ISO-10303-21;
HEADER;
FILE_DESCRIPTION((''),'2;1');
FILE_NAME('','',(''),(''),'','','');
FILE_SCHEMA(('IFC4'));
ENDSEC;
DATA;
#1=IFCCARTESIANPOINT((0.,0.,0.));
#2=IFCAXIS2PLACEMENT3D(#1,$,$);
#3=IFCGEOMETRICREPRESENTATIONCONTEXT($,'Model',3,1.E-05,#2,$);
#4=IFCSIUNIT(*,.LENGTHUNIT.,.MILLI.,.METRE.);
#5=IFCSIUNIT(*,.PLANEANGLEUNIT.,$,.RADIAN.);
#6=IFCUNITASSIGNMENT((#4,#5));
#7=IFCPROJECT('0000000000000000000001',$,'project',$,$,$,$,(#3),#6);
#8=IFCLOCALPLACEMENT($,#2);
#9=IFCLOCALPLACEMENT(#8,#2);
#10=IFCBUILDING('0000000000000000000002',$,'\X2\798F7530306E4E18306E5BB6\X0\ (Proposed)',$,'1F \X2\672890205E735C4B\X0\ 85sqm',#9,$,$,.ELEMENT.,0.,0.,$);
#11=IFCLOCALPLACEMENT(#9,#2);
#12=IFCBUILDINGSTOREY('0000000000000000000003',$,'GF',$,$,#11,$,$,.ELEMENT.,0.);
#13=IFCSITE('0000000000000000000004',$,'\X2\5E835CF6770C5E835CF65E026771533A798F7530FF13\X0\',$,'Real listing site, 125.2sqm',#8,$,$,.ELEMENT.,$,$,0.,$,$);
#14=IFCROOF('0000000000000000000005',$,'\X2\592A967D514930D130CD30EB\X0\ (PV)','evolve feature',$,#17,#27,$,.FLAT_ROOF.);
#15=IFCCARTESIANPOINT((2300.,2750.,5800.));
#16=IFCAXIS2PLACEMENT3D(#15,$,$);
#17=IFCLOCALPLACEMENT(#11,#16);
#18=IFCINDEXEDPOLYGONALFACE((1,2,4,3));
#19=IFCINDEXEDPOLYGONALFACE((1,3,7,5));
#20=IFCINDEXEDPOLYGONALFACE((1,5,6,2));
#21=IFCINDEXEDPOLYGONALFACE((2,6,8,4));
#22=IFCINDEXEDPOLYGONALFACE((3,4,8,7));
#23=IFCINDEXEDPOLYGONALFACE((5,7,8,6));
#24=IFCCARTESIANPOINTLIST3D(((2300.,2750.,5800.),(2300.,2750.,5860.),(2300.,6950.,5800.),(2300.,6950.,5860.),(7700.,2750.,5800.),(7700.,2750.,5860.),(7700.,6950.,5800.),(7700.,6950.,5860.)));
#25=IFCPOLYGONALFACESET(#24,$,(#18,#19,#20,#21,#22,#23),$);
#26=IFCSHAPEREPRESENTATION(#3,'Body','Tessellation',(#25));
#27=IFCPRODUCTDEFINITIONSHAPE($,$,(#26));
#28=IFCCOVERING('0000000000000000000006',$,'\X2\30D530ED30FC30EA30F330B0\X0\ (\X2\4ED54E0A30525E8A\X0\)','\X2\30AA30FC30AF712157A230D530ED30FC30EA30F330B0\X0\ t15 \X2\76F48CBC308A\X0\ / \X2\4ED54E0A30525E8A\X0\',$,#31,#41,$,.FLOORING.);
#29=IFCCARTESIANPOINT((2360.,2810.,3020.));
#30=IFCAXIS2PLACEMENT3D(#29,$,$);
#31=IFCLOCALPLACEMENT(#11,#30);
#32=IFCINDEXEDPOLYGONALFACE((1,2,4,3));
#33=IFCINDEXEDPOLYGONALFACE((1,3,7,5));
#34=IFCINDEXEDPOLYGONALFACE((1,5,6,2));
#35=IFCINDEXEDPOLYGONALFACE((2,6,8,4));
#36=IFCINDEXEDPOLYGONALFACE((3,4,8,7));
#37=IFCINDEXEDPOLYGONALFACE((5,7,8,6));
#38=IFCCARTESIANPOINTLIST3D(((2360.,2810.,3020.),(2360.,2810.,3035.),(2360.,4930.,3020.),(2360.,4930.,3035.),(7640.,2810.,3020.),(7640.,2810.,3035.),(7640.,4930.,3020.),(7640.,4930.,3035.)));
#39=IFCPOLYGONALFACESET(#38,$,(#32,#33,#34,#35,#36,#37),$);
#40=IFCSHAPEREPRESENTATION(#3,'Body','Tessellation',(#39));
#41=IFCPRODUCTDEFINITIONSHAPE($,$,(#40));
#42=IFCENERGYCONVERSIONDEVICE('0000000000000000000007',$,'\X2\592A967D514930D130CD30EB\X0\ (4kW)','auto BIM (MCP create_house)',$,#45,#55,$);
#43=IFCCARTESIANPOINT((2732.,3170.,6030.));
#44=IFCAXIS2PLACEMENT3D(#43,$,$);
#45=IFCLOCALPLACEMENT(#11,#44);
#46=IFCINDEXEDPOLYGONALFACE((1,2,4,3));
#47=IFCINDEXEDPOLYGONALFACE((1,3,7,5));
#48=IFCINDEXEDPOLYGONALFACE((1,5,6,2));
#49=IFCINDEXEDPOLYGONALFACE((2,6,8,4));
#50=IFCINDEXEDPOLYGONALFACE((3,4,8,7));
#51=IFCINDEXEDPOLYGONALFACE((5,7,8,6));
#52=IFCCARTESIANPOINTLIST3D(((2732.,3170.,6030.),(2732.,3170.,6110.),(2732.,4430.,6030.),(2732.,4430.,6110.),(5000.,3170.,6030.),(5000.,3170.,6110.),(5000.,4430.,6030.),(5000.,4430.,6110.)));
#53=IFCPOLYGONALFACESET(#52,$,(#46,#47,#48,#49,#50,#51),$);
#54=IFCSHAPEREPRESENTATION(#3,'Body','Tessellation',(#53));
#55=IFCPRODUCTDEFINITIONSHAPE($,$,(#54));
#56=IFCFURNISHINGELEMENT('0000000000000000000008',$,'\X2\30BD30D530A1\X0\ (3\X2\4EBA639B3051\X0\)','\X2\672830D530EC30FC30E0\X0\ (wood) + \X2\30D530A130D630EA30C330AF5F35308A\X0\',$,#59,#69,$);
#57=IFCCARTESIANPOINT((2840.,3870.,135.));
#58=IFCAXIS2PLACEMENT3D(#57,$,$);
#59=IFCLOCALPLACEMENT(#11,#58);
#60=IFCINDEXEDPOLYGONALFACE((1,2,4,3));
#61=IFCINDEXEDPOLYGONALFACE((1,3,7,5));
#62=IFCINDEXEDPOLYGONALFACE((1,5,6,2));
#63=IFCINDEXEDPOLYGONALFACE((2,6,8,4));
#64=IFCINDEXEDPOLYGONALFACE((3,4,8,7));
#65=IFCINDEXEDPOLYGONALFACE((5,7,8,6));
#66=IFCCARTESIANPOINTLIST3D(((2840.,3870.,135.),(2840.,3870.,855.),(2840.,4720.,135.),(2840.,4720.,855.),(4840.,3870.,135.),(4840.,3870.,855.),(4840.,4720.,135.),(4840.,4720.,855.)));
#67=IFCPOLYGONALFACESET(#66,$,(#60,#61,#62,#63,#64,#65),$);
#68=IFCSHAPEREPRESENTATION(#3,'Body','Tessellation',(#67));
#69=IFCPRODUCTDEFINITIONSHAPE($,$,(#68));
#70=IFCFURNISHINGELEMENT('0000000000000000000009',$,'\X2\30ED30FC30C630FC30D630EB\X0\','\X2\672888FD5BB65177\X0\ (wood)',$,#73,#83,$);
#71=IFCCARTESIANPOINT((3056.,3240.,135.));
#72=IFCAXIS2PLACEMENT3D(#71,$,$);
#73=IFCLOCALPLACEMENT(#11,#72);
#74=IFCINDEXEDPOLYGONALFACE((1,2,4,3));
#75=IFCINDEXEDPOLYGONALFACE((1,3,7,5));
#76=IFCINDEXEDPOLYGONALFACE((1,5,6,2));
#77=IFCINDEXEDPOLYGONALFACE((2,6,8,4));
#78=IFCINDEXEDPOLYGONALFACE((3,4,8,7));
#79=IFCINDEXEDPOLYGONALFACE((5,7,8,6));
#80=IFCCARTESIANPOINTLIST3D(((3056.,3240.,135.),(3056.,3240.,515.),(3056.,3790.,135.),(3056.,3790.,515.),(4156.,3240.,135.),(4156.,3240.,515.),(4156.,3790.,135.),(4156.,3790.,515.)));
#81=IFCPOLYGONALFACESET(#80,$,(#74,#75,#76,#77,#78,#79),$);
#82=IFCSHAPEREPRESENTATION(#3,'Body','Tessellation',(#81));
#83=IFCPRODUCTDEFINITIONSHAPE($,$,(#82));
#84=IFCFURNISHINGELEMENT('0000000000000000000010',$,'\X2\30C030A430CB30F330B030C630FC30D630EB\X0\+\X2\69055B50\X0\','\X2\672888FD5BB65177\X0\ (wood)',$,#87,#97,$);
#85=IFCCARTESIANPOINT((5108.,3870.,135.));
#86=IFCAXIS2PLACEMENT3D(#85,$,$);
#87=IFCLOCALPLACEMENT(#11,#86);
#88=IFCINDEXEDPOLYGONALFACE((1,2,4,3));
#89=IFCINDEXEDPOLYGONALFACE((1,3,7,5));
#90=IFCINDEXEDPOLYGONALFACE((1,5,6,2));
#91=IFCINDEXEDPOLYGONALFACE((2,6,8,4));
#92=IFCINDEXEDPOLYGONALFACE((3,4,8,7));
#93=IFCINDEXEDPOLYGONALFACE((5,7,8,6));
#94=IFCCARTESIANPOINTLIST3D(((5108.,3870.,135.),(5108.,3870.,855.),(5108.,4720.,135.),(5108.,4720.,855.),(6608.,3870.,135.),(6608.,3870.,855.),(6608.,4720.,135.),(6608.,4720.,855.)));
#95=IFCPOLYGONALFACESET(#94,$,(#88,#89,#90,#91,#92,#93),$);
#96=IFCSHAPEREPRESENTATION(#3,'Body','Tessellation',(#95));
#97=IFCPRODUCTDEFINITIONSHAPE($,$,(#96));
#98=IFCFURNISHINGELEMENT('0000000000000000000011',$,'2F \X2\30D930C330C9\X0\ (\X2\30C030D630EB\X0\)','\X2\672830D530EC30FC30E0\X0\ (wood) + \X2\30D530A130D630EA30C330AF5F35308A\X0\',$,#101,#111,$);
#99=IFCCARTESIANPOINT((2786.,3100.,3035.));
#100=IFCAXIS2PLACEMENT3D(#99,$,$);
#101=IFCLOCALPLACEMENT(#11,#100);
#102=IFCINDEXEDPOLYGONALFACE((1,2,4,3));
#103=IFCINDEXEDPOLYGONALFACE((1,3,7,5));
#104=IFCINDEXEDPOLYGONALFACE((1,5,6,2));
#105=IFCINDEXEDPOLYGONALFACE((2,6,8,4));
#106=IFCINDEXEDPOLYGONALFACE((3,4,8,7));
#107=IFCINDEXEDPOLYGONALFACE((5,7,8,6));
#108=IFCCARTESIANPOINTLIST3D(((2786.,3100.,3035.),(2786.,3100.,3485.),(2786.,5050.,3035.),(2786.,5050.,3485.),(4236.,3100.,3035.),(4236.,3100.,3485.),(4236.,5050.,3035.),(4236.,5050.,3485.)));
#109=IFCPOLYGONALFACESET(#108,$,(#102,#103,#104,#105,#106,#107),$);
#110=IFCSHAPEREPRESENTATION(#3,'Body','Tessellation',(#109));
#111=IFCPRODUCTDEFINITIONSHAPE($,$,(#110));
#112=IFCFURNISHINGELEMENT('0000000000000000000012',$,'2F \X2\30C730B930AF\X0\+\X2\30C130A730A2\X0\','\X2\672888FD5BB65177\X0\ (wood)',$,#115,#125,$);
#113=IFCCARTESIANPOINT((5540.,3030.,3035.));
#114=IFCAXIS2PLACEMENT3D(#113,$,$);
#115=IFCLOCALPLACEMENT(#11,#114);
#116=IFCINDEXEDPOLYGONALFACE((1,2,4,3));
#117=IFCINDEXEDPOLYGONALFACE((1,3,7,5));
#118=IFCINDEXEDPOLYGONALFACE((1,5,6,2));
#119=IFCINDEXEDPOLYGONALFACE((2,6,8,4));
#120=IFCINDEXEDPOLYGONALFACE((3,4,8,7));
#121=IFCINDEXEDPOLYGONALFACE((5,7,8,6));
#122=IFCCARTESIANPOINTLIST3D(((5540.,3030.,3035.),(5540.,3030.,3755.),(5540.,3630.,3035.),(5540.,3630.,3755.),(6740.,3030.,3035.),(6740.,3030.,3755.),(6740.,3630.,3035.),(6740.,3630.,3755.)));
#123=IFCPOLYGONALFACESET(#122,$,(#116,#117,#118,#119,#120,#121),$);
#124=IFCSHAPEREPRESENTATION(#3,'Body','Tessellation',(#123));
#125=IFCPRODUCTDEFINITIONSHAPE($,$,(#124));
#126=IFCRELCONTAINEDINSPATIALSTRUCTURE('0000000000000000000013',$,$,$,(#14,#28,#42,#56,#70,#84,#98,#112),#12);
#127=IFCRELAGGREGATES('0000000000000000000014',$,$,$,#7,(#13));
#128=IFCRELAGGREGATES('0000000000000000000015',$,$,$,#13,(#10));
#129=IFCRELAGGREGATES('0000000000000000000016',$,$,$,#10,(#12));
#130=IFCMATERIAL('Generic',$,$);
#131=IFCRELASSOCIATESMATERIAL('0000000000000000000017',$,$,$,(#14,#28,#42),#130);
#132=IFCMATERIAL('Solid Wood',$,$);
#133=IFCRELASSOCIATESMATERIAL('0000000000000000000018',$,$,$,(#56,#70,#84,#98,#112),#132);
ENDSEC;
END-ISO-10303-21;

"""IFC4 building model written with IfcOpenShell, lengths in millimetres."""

from ifc_helpers import new_model, si_unit, frame, frame_2d, origin, place, context, project, spatial, rectangle, extrude, material, element, save


model = new_model("IFC4")

# Units and contexts
model_context = context("Model", 3, precision=1e-05, world=origin())
ifc_project = project(units=[si_unit("LENGTHUNIT", "METRE", prefix="MILLI"), si_unit("PLANEANGLEUNIT", "RADIAN")], contexts=[model_context])

# Site, building, storey
site_placement = place(None, origin())
site = spatial("IfcSite", under=ifc_project, at=site_placement, Name="広島県広島市東区福田３", ObjectType="Real listing site, 125.2sqm", CompositionType="ELEMENT", RefElevation=0.0)
building_placement = place(site_placement, origin())
building = spatial("IfcBuilding", under=site, at=building_placement, Name="福田の丘の家 (Proposed)", ObjectType="1F 木造平屋 85sqm", CompositionType="ELEMENT", ElevationOfRefHeight=0.0, ElevationOfTerrain=0.0)
storey_placement = place(building_placement, origin())
storey = spatial("IfcBuildingStorey", under=building, at=storey_placement, Name="GF", CompositionType="ELEMENT", Elevation=0.0)

# Shared definitions
ifc_material_1 = material(Name="Solid Wood")

# Roof
ifc_material_2 = material(Name="Generic")
roof_1_placement = place(storey_placement, frame((2300.0, 2750.0, 5800.0)))
element("IfcRoof", 1, at=roof_1_placement, inside=storey, material=ifc_material_2, Name="太陽光パネル (PV)", Description="evolve feature", PredefinedType="FLAT_ROOF", context=model_context, shape_type="SweptSolid", body=[
    extrude(rectangle(XDim=5400.0, YDim=4200.0, at=frame_2d((2700.0, 2100.0))), frame((2300.0, 2750.0, 5800.0)), (0.0, 0.0, 1.0), 60.0),
])

# Covering
covering_placement = place(storey_placement, frame((2360.0, 2810.0, 3020.0)))
element("IfcCovering", 2, at=covering_placement, inside=storey, material=ifc_material_2, Name="フローリング (仕上げ床)", Description="オーク無垢フローリング t15 直貼り / 仕上げ床", PredefinedType="FLOORING", context=model_context, shape_type="SweptSolid", body=[
    extrude(rectangle(XDim=5280.0, YDim=2120.0, at=frame_2d((2640.0, 1060.0))), frame((2360.0, 2810.0, 3020.0)), (0.0, 0.0, 1.0), 15.0),
])

# Energy conversion device
energy_conversion_device_placement = place(storey_placement, frame((2732.0, 3170.0, 6030.0)))
element("IfcEnergyConversionDevice", 3, at=energy_conversion_device_placement, inside=storey, material=ifc_material_2, Name="太陽光パネル (4kW)", Description="auto BIM (MCP create_house)", context=model_context, shape_type="SweptSolid", body=[
    extrude(rectangle(XDim=2268.0, YDim=1260.0, at=frame_2d((1134.0, 630.0))), frame((2732.0, 3170.0, 6030.0)), (0.0, 0.0, 1.0), 80.0),
])

# Furnishing elements
furnishing_1_placement = place(storey_placement, frame((2840.0, 3870.0, 135.0)))
element("IfcFurnishingElement", 4, at=furnishing_1_placement, inside=storey, material=ifc_material_1, Name="ソファ (3人掛け)", Description="木フレーム (wood) + ファブリック張り", context=model_context, shape_type="SweptSolid", body=[
    extrude(rectangle(XDim=2000.0, YDim=850.0, at=frame_2d((1000.0, 425.0))), frame((2840.0, 3870.0, 135.0)), (0.0, 0.0, 1.0), 720.0),
])
furnishing_2_placement = place(storey_placement, frame((3056.0, 3240.0, 135.0)))
element("IfcFurnishingElement", 5, at=furnishing_2_placement, inside=storey, material=ifc_material_1, Name="ローテーブル", Description="木製家具 (wood)", context=model_context, shape_type="SweptSolid", body=[
    extrude(rectangle(XDim=1100.0, YDim=550.0, at=frame_2d((550.0, 275.0))), frame((3056.0, 3240.0, 135.0)), (0.0, 0.0, 1.0), 380.0),
])
furnishing_3_placement = place(storey_placement, frame((5108.0, 3870.0, 135.0)))
element("IfcFurnishingElement", 6, at=furnishing_3_placement, inside=storey, material=ifc_material_1, Name="ダイニングテーブル+椅子", Description="木製家具 (wood)", context=model_context, shape_type="SweptSolid", body=[
    extrude(rectangle(XDim=1500.0, YDim=850.0, at=frame_2d((750.0, 425.0))), frame((5108.0, 3870.0, 135.0)), (0.0, 0.0, 1.0), 720.0),
])
furnishing_4_placement = place(storey_placement, frame((2786.0, 3100.0, 3035.0)))
element("IfcFurnishingElement", 7, at=furnishing_4_placement, inside=storey, material=ifc_material_1, Name="2F ベッド (ダブル)", Description="木フレーム (wood) + ファブリック張り", context=model_context, shape_type="SweptSolid", body=[
    extrude(rectangle(XDim=1450.0, YDim=1950.0, at=frame_2d((725.0, 975.0))), frame((2786.0, 3100.0, 3035.0)), (0.0, 0.0, 1.0), 450.0),
])
furnishing_5_placement = place(storey_placement, frame((5540.0, 3030.0, 3035.0)))
element("IfcFurnishingElement", 8, at=furnishing_5_placement, inside=storey, material=ifc_material_1, Name="2F デスク+チェア", Description="木製家具 (wood)", context=model_context, shape_type="SweptSolid", body=[
    extrude(rectangle(XDim=1200.0, YDim=600.0, at=frame_2d((600.0, 300.0))), frame((5540.0, 3030.0, 3035.0)), (0.0, 0.0, 1.0), 720.0),
])

save(model, "model.ifc")
